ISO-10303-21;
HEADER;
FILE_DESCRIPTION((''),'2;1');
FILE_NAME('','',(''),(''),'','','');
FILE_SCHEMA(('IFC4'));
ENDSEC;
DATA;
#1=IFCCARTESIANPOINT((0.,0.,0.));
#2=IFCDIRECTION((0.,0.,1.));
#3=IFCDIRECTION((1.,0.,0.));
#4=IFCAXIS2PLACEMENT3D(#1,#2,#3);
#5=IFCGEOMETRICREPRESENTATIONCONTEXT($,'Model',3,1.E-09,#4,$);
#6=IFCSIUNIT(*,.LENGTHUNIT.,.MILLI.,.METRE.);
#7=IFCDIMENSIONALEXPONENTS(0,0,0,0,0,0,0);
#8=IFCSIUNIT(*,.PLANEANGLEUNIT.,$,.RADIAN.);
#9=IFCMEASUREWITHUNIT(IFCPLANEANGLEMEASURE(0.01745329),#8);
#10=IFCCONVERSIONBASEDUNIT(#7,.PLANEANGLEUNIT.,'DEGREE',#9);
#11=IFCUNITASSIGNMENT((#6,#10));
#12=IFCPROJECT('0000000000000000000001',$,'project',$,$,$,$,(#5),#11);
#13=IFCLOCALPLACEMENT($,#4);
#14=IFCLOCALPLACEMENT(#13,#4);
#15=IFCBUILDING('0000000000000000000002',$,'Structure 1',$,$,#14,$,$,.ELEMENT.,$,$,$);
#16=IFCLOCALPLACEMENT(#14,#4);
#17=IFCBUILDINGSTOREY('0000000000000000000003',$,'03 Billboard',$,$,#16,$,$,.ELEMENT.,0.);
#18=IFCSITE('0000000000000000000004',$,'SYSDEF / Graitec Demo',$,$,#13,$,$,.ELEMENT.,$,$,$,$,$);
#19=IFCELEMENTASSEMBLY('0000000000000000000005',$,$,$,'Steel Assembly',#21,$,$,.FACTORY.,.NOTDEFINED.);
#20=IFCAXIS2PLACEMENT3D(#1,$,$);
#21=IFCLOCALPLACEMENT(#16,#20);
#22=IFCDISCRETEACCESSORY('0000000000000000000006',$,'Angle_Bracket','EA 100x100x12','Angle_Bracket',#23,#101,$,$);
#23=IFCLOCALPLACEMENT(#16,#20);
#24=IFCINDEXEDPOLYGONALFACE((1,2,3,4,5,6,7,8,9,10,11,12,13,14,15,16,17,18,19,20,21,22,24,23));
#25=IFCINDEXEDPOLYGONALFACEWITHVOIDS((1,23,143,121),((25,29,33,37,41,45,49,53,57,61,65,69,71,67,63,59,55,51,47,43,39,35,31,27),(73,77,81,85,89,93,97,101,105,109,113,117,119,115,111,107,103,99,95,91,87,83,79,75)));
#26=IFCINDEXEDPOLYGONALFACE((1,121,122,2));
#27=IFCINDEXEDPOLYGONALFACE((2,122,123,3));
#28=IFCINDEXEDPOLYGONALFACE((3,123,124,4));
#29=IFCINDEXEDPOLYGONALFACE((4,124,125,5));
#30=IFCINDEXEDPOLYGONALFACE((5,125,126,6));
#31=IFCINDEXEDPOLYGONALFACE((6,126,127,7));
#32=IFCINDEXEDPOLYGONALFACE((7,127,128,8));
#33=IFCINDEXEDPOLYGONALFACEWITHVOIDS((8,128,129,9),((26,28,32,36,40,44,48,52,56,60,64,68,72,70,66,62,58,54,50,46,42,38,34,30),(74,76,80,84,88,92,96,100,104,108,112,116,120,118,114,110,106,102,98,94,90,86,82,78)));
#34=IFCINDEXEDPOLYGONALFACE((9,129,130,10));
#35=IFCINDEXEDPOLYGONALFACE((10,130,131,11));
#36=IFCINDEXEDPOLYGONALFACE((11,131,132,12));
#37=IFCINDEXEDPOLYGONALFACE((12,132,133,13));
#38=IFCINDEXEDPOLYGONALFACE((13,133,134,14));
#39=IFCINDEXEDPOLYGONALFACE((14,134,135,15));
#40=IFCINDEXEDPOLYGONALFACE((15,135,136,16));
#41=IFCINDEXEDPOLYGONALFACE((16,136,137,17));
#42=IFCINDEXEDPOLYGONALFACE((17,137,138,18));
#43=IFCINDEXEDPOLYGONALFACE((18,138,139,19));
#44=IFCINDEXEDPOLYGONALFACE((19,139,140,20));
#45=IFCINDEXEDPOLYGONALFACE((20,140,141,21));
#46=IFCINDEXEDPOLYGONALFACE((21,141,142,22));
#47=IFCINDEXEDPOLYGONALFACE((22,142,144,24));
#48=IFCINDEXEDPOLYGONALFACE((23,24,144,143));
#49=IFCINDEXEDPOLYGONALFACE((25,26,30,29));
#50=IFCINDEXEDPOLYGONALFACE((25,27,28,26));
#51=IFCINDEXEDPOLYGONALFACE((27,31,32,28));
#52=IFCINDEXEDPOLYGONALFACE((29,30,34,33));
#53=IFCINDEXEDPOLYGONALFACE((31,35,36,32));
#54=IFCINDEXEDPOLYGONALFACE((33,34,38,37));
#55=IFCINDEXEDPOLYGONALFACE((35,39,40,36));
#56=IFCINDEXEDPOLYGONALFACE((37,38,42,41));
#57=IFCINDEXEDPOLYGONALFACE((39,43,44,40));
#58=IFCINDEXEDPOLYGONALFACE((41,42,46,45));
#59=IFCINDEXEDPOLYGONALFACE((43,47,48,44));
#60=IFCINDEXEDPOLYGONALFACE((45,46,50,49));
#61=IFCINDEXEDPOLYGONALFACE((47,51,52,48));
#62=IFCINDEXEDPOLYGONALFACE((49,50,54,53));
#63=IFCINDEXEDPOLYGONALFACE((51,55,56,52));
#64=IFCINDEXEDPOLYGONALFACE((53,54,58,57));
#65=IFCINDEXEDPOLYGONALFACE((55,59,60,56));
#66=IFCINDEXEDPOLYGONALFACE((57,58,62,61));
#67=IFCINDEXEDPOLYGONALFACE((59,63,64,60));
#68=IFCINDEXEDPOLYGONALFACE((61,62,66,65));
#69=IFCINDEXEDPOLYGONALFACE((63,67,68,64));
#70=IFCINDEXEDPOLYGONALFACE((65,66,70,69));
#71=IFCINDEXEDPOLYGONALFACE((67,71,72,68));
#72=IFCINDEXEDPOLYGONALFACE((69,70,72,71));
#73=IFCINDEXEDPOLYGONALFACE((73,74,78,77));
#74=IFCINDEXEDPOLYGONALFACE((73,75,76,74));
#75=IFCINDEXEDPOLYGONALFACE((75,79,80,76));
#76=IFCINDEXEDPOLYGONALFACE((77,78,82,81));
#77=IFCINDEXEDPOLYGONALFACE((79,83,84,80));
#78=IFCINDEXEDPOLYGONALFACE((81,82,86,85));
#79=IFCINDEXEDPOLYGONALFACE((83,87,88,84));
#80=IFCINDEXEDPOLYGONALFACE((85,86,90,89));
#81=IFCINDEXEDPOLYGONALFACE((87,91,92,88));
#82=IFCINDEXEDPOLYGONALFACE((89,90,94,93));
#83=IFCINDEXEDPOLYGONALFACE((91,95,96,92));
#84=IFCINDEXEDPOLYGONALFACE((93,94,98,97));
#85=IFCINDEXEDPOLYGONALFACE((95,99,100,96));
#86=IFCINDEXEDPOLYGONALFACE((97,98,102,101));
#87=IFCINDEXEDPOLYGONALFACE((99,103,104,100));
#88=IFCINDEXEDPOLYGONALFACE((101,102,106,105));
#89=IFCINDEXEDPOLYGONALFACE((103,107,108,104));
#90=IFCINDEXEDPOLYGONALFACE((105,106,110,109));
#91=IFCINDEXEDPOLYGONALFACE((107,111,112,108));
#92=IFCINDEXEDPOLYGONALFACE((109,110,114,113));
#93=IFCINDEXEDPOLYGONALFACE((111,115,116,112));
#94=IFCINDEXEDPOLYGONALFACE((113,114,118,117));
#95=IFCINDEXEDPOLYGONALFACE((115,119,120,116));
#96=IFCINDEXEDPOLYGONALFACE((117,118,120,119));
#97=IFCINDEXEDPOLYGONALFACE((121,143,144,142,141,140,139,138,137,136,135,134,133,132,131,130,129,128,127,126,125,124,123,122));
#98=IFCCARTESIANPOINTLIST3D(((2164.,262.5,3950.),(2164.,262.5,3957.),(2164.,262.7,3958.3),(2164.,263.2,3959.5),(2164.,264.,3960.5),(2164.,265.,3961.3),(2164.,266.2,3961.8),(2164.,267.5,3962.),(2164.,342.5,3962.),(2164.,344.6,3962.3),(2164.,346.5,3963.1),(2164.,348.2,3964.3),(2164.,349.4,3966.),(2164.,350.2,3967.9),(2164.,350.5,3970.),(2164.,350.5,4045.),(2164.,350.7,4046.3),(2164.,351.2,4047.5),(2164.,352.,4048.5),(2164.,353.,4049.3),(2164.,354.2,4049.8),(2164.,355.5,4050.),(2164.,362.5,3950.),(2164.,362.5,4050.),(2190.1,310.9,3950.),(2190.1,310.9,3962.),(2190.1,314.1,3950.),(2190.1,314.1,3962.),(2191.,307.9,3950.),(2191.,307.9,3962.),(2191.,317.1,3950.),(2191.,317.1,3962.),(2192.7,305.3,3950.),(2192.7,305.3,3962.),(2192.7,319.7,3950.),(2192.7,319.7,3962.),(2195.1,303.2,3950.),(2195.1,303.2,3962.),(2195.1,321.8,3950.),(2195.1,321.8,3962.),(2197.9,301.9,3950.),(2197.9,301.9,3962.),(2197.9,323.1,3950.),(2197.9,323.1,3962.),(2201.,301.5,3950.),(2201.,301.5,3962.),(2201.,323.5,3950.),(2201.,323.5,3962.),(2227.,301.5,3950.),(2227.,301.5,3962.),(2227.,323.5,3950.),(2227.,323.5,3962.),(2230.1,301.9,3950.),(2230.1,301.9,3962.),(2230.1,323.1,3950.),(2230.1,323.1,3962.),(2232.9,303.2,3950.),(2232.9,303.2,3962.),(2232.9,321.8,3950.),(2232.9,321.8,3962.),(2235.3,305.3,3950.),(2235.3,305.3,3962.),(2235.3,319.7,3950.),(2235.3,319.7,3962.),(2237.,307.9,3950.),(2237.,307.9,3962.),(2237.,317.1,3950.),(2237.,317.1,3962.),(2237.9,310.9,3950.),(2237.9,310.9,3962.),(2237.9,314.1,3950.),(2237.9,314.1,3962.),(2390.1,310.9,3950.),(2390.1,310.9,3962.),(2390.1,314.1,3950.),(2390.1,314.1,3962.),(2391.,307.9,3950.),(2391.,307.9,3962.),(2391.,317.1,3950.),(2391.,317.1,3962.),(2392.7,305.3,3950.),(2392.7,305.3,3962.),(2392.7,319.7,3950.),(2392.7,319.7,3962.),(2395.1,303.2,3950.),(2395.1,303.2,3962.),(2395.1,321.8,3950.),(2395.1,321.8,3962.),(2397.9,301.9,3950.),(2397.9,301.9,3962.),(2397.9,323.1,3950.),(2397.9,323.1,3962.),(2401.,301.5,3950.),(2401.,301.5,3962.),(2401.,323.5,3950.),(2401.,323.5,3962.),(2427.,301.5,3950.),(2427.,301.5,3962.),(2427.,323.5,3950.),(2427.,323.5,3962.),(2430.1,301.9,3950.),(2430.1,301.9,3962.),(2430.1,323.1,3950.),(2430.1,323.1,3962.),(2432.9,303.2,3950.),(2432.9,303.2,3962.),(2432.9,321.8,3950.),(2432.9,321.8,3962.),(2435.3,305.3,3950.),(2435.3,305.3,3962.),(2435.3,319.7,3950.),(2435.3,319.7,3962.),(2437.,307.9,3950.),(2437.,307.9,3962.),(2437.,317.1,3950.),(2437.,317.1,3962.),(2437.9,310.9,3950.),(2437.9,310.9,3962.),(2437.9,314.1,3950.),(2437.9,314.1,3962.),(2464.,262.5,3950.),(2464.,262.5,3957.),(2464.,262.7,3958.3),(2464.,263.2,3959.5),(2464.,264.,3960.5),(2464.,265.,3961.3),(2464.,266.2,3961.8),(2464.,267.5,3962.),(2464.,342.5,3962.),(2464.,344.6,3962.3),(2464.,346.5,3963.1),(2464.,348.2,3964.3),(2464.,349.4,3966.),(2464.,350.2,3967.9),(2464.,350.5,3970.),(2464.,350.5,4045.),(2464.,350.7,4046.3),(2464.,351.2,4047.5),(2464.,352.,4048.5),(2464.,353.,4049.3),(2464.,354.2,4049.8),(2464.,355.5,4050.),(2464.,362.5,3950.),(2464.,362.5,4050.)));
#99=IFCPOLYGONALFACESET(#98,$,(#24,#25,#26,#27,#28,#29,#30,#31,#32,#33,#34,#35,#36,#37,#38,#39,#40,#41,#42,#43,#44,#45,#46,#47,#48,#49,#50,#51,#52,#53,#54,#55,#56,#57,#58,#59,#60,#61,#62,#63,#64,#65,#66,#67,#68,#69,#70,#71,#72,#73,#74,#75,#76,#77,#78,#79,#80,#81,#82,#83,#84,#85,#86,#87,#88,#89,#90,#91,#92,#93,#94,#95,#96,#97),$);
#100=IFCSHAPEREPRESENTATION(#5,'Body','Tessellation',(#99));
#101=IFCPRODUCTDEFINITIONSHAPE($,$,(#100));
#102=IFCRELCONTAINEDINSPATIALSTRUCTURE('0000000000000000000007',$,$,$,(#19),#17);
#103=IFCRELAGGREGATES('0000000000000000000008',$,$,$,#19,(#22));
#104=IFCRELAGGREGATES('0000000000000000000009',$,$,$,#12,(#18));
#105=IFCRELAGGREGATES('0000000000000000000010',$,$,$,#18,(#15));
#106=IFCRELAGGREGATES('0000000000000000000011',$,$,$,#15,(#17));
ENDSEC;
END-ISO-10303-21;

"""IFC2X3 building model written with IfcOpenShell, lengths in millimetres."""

from ifc_helpers import new_model, entity, si_unit, converted_unit, point, frame, frame_2d, origin, origin_with_axes, place, context, project, spatial, circle_curve, line_curve, trimmed, segment, composite_curve, l_section, outline, extrude, element, aggregate, save


model = new_model("IFC2X3")

# Units and contexts
model_context = context("Model", 3, precision=1e-09, world=origin_with_axes())
ifc_project = project(units=[si_unit("LENGTHUNIT", "METRE", prefix="MILLI"), converted_unit("PLANEANGLEUNIT", "DEGREE", entity("IfcPlaneAngleMeasure", 0.01745329), si_unit("PLANEANGLEUNIT", "RADIAN"), dimensions=[0, 0, 0, 0, 0, 0, 0])], contexts=[model_context])

# Site, building, storey
site_placement = place(None, origin_with_axes())
site = spatial("IfcSite", under=ifc_project, at=site_placement, Name="SYSDEF / Graitec Demo", CompositionType="ELEMENT")
building_placement = place(site_placement, origin_with_axes())
building = spatial("IfcBuilding", under=site, at=building_placement, Name="Structure 1", CompositionType="ELEMENT")
storey_placement = place(building_placement, origin_with_axes())
storey = spatial("IfcBuildingStorey", under=building, at=storey_placement, Name="03 Billboard", CompositionType="ELEMENT", Elevation=0.0)

# Element assembly, discrete accessory, openings
assembly_1_placement = place(None, frame((-4239.1, -387.5, 4000.0), z_axis=(-1.0, 0.0, 0.0), x_axis=(0.0, 0.0, 1.0)))
assembly_1 = element("IfcElementAssembly", 1, at=assembly_1_placement, inside=storey, ObjectType="Steel Assembly", AssemblyPlace="FACTORY", PredefinedType="NOTDEFINED")
discrete_accessory_1_placement = place(assembly_1_placement, frame((-20.8, 720.8, -6403.1), z_axis=(0.0, 0.0, 1.0), x_axis=(0.0, -1.0, 0.0)))
discrete_accessory_1 = element("IfcDiscreteAccessory", 2, at=discrete_accessory_1_placement, Name="Angle_Bracket", Description="EA 100x100x12", ObjectType="Angle_Bracket", context=model_context, shape_type="SweptSolid", body=[
    extrude(l_section(Depth=100.0, Width=100.0, Thickness=12.0, FilletRadius=8.0, EdgeRadius=5.0, at=frame_2d((20.8, 20.8))), origin(), (0.0, 0.0, -1.0), 300.0),
])
opening_1_placement = place(discrete_accessory_1_placement, frame((20.8, -16.7, -150.0), z_axis=(0.0, -1.0, 0.0), x_axis=(0.0, 0.0, 1.0)))
element("IfcOpeningElement", 3, at=opening_1_placement, cuts=discrete_accessory_1, ObjectType="Opening", context=model_context, shape_type="SweptSolid", body=[
    extrude(outline(composite_curve([segment(trimmed(line_curve((87.0, -11.0), (1.0, 0.0), 26.0), [point((87.0, -11.0))], [point((113.0, -11.0))], True, "CARTESIAN"), True, "CONTINUOUS"), segment(trimmed(circle_curve(frame_2d((113.0, 0.0), x_axis=(1.0, 0.0)), 11.0), [point((113.0, -11.0))], [point((113.0, 11.0))], True, "CARTESIAN"), True, "CONTINUOUS"), segment(trimmed(line_curve((113.0, 11.0), (-1.0, 0.0), 26.0), [point((113.0, 11.0))], [point((87.0, 11.0))], True, "CARTESIAN"), True, "CONTINUOUS"), segment(trimmed(circle_curve(frame_2d((87.0, 0.0), x_axis=(1.0, 0.0)), 11.0), [point((87.0, 11.0))], [point((87.0, -11.0))], True, "CARTESIAN"), True, "CONTINUOUS")], self_intersect=False)), origin(), (0.0, 0.0, 1.0), 13.0),
])
opening_2_placement = place(discrete_accessory_1_placement, frame((20.8, -16.7, -150.0), z_axis=(0.0, -1.0, 0.0), x_axis=(0.0, 0.0, 1.0)))
element("IfcOpeningElement", 4, at=opening_2_placement, cuts=discrete_accessory_1, ObjectType="Opening", context=model_context, shape_type="SweptSolid", body=[
    extrude(outline(composite_curve([segment(trimmed(line_curve((-113.0, -11.0), (1.0, 0.0), 26.0), [point((-113.0, -11.0))], [point((-87.0, -11.0))], True, "CARTESIAN"), True, "CONTINUOUS"), segment(trimmed(circle_curve(frame_2d((-87.0, 0.0), x_axis=(1.0, 0.0)), 11.0), [point((-87.0, -11.0))], [point((-87.0, 11.0))], True, "CARTESIAN"), True, "CONTINUOUS"), segment(trimmed(line_curve((-87.0, 11.0), (-1.0, 0.0), 26.0), [point((-87.0, 11.0))], [point((-113.0, 11.0))], True, "CARTESIAN"), True, "CONTINUOUS"), segment(trimmed(circle_curve(frame_2d((-113.0, 0.0), x_axis=(1.0, 0.0)), 11.0), [point((-113.0, 11.0))], [point((-113.0, -11.0))], True, "CARTESIAN"), True, "CONTINUOUS")], self_intersect=False)), origin(), (0.0, 0.0, 1.0), 13.0),
])
aggregate(assembly_1, [discrete_accessory_1])

save(model, "model.ifc")
